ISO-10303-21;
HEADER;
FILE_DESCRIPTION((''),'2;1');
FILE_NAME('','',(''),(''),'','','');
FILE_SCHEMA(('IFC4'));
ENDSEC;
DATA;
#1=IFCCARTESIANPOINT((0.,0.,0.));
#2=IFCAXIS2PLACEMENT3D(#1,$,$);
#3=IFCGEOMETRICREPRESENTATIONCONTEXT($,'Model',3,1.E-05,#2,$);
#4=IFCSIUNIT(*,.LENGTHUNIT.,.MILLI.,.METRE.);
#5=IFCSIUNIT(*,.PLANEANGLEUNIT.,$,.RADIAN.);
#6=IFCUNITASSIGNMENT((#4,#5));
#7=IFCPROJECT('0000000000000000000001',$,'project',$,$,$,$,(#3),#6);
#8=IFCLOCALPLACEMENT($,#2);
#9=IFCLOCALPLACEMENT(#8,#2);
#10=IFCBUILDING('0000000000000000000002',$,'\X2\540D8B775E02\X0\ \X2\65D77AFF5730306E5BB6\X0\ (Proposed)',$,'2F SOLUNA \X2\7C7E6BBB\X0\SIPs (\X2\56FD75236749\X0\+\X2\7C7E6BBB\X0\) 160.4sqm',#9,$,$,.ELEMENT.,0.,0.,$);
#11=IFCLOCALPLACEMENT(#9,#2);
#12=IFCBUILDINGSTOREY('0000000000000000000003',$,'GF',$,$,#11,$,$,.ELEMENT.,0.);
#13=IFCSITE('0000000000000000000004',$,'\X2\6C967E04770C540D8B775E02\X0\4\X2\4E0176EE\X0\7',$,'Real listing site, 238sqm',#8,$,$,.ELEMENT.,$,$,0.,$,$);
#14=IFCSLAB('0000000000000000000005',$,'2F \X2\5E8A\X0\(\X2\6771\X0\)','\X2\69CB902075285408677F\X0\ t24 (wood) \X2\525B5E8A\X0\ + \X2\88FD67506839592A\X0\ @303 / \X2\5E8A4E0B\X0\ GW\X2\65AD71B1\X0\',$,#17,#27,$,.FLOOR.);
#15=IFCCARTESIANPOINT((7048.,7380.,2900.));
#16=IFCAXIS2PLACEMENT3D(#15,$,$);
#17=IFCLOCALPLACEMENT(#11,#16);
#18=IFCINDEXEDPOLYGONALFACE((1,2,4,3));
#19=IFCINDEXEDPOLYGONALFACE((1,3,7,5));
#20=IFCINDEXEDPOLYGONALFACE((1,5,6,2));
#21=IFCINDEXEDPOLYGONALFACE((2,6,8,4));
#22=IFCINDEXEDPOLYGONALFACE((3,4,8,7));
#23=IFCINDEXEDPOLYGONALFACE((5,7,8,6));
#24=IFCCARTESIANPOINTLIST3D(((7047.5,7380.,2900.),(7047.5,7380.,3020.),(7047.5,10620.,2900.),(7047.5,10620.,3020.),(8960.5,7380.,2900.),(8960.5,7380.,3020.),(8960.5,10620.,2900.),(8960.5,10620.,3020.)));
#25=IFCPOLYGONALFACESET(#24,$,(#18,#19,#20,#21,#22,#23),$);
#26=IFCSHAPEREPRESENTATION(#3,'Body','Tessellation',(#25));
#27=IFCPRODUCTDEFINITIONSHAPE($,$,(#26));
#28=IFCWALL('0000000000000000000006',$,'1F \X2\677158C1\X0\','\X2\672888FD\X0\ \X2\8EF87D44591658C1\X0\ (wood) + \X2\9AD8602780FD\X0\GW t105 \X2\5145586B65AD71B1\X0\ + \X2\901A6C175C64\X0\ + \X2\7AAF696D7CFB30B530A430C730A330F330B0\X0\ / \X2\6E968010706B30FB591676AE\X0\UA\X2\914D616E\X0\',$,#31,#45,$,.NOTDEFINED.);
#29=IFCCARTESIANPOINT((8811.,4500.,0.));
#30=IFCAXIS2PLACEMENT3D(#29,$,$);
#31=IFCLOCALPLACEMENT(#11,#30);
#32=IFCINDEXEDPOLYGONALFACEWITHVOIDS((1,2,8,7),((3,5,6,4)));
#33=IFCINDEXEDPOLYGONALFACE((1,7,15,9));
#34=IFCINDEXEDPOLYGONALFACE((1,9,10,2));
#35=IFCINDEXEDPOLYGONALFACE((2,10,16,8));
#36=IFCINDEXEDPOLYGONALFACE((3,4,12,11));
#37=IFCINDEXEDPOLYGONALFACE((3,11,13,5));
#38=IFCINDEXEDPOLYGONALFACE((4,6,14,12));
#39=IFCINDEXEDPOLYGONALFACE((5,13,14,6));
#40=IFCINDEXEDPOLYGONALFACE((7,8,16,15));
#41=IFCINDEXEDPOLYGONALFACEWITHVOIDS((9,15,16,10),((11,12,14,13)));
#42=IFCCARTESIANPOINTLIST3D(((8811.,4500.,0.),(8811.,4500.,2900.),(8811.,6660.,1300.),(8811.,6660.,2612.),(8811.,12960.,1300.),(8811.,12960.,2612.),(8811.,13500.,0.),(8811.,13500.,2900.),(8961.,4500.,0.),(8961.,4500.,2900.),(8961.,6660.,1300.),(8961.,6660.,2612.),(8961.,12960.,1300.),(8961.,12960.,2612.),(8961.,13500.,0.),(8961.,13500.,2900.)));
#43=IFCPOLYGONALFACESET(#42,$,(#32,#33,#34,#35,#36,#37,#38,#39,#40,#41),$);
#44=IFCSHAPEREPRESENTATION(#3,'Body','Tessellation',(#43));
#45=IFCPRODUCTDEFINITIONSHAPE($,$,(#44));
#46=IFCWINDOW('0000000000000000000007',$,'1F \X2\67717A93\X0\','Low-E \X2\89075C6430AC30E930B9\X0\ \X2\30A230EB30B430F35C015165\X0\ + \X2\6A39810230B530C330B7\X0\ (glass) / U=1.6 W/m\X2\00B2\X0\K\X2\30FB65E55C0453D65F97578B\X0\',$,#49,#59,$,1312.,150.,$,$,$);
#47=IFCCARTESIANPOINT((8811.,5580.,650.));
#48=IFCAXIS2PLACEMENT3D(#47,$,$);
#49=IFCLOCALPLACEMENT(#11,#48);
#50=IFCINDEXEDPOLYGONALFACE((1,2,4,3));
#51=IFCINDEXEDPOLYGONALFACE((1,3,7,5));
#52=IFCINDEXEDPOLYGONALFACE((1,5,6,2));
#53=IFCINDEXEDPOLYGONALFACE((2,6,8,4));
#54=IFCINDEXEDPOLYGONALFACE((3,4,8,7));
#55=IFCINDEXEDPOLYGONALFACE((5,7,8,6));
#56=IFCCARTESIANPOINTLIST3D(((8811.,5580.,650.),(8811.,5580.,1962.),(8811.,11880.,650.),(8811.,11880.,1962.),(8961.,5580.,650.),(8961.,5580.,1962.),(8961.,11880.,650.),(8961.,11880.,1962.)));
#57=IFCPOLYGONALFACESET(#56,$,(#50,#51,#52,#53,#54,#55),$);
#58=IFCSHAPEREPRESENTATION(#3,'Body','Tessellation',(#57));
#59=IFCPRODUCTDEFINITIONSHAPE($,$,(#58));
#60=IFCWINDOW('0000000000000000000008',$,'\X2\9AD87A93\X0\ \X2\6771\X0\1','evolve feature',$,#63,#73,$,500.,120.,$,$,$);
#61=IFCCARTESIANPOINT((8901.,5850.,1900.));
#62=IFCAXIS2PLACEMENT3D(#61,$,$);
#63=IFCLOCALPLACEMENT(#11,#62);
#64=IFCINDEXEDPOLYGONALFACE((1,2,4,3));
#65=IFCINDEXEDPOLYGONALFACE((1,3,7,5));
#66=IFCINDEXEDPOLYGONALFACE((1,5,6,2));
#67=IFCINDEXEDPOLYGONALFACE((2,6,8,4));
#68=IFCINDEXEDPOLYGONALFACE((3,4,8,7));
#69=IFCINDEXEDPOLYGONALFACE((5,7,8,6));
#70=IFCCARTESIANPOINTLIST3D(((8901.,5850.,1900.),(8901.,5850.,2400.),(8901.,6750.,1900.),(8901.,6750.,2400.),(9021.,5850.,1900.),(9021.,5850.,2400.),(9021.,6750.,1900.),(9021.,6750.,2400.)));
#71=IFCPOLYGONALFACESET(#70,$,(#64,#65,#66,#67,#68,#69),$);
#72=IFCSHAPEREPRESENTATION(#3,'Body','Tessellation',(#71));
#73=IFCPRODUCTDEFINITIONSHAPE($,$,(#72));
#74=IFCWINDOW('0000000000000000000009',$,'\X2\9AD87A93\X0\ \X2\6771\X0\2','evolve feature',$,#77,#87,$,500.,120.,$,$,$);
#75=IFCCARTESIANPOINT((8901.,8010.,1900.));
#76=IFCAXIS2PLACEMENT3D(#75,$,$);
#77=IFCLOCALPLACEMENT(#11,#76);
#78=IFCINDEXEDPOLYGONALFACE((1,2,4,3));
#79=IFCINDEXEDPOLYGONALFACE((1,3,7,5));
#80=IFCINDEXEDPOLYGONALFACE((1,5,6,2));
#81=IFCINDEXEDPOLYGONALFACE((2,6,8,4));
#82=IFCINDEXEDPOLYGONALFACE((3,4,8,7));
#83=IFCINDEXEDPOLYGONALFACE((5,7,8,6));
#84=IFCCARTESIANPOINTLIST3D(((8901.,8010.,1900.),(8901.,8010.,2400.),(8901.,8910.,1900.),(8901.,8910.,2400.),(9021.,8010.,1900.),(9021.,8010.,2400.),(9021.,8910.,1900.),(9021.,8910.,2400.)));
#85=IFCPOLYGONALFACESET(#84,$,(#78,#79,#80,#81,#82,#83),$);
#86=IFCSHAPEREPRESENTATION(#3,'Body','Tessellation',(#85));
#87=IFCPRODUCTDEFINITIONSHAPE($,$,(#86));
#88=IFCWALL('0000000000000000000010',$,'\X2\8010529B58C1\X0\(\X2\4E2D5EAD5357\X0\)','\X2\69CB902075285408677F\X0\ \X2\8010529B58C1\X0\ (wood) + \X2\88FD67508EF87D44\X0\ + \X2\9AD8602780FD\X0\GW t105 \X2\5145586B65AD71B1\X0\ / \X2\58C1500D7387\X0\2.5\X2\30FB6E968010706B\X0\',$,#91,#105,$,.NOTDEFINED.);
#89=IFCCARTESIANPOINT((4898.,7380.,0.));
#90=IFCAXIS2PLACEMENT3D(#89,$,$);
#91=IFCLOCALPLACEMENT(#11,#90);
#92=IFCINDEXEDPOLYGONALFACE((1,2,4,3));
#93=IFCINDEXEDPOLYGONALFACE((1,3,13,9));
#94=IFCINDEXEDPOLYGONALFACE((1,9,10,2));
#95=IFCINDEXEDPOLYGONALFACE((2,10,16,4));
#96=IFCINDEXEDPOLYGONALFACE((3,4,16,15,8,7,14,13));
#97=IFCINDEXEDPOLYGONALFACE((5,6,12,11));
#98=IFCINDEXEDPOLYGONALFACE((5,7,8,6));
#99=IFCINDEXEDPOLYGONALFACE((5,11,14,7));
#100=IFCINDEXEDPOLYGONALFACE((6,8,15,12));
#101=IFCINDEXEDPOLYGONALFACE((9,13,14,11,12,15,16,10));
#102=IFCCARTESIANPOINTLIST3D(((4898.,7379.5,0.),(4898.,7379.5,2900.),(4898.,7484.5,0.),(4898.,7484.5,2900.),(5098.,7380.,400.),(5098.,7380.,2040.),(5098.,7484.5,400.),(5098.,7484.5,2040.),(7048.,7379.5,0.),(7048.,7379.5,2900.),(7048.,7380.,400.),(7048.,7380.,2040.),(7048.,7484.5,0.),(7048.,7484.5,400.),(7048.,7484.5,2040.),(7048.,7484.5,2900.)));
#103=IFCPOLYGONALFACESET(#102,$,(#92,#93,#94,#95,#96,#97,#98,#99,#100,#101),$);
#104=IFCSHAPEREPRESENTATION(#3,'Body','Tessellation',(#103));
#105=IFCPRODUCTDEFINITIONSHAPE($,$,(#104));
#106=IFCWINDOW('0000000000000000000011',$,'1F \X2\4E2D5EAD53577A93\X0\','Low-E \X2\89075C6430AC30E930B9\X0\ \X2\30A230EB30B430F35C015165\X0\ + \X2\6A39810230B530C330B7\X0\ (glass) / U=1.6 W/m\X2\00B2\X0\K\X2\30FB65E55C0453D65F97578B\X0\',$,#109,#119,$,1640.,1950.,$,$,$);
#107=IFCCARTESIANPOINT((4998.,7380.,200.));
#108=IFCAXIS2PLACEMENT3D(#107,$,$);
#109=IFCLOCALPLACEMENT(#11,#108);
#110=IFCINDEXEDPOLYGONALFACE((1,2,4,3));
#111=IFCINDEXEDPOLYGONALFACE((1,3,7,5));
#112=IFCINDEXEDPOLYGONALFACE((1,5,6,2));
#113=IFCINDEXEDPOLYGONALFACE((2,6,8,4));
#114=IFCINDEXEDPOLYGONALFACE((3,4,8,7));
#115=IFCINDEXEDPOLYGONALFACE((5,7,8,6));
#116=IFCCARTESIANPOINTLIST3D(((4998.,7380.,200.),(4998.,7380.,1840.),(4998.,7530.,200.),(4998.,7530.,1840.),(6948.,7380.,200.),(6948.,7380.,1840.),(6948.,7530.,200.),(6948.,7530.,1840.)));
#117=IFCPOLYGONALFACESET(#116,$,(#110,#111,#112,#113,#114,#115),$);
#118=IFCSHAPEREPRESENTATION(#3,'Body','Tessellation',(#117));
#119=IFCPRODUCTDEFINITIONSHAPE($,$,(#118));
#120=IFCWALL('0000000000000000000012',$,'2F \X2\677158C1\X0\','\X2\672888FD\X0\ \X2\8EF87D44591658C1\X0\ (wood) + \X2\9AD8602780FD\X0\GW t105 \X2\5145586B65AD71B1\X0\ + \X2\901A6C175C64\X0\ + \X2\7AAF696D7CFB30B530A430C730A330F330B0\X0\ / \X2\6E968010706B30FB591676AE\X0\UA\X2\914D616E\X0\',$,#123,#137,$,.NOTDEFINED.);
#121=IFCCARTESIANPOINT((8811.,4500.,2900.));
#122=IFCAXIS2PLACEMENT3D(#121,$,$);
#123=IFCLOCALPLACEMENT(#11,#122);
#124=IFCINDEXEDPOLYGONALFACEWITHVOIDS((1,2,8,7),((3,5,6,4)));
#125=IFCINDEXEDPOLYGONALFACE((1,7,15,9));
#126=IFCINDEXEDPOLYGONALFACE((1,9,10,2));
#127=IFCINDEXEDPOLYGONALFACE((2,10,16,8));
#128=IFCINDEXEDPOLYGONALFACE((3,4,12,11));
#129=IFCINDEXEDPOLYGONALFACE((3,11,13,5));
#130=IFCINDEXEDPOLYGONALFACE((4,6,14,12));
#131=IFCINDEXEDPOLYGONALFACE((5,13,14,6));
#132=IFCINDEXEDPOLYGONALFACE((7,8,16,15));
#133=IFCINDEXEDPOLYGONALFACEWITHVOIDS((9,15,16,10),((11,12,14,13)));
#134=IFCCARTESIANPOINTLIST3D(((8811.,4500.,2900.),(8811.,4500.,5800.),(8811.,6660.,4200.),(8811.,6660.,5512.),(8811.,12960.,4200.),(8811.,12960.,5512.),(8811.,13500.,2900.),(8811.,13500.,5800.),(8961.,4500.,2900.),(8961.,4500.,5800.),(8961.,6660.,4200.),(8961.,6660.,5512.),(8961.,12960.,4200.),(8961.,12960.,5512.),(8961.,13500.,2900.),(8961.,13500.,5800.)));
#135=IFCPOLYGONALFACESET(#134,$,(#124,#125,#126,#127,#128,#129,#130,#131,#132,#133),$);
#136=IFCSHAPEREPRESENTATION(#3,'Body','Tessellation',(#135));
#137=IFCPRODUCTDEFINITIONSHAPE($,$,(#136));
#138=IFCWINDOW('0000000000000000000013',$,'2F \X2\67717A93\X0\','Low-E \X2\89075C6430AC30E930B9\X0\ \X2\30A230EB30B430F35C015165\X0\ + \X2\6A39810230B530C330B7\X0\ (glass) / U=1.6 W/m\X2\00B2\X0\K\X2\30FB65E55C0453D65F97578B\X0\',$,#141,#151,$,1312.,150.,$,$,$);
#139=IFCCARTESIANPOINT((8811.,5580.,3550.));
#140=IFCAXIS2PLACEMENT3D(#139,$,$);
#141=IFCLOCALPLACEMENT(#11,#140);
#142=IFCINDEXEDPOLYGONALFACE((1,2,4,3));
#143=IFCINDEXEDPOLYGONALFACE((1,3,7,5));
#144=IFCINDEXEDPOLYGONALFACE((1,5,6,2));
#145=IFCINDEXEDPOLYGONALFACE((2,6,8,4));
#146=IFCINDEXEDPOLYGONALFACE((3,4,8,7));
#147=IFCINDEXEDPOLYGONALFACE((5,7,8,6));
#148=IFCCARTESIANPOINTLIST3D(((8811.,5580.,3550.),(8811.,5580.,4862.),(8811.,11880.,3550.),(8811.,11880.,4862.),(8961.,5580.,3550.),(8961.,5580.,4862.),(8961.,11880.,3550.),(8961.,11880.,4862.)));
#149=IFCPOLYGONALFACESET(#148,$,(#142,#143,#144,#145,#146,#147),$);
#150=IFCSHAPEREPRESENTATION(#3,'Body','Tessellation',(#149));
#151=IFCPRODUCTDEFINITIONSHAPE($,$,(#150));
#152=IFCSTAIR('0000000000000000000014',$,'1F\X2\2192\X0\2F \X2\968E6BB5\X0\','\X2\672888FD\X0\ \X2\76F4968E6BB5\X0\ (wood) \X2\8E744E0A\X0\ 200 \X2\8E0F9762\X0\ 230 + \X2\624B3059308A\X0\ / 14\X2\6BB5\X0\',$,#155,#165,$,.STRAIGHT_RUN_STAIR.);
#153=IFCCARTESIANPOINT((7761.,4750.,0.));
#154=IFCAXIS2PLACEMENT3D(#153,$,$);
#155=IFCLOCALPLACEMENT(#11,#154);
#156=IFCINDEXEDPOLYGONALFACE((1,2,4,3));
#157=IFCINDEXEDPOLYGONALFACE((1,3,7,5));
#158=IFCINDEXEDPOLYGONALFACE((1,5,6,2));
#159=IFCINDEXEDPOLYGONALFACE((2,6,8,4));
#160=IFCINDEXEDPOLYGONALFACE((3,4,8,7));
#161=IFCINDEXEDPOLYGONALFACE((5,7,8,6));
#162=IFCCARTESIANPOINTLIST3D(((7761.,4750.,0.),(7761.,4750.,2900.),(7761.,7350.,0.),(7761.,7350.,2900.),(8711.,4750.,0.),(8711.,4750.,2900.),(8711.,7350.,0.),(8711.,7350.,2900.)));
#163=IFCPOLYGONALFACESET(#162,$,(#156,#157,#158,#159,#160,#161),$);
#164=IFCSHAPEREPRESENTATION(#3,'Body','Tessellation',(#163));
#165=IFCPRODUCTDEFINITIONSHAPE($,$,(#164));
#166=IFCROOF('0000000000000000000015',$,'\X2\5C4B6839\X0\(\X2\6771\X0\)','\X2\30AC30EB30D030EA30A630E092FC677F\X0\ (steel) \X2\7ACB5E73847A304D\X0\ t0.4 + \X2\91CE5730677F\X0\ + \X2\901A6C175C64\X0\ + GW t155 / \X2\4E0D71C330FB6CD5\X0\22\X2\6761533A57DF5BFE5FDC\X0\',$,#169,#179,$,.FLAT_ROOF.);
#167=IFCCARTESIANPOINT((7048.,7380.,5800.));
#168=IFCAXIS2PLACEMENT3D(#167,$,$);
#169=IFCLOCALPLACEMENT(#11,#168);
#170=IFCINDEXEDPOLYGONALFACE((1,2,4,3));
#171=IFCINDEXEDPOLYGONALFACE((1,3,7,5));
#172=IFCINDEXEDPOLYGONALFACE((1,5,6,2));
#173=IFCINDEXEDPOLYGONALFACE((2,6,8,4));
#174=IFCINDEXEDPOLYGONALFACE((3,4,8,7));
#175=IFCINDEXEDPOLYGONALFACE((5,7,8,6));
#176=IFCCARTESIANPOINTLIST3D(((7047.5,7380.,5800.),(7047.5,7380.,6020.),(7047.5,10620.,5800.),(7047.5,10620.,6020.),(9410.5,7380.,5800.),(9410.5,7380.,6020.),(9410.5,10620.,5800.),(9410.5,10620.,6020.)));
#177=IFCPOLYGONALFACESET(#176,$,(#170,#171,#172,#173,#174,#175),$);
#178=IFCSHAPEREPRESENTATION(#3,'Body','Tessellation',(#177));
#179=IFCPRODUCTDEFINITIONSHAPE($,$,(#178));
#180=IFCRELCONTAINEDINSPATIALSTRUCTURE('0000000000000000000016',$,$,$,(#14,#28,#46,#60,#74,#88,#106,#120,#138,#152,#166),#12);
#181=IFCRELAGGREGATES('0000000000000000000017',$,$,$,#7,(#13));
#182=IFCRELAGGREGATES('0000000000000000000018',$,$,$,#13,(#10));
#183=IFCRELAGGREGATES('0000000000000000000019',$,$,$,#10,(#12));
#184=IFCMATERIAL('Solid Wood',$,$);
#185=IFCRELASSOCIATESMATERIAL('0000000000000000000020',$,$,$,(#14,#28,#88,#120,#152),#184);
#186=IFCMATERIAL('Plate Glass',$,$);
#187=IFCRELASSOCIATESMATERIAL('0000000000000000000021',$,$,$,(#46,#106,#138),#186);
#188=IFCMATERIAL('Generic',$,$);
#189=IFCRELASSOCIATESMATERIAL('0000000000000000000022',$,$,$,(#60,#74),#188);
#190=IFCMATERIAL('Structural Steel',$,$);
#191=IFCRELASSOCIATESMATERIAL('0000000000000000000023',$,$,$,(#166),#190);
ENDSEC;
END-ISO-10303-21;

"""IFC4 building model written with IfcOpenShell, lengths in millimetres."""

from ifc_helpers import new_model, si_unit, frame, frame_2d, origin, place, context, project, spatial, rectangle, extrude, material, element, fill, save


model = new_model("IFC4")

# Units and contexts
model_context = context("Model", 3, precision=1e-05, world=origin())
ifc_project = project(units=[si_unit("LENGTHUNIT", "METRE", prefix="MILLI"), si_unit("PLANEANGLEUNIT", "RADIAN")], contexts=[model_context])

# Site, building, storey
site_placement = place(None, origin())
site = spatial("IfcSite", under=ifc_project, at=site_placement, Name="沖縄県名護市4丁目7", ObjectType="Real listing site, 238sqm", CompositionType="ELEMENT", RefElevation=0.0)
building_placement = place(site_placement, origin())
building = spatial("IfcBuilding", under=site, at=building_placement, Name="名護市 旗竿地の家 (Proposed)", ObjectType="2F SOLUNA 籾殻SIPs (国産杉+籾殻) 160.4sqm", CompositionType="ELEMENT", ElevationOfRefHeight=0.0, ElevationOfTerrain=0.0)
storey_placement = place(building_placement, origin())
storey = spatial("IfcBuildingStorey", under=building, at=storey_placement, Name="GF", CompositionType="ELEMENT", Elevation=0.0)

# Slab
ifc_material_1 = material(Name="Solid Wood")
slab_1_placement = place(storey_placement, frame((7048.0, 7380.0, 2900.0)))
element("IfcSlab", 1, at=slab_1_placement, inside=storey, material=ifc_material_1, Name="2F 床(東)", Description="構造用合板 t24 (wood) 剛床 + 製材根太 @303 / 床下 GW断熱", PredefinedType="FLOOR", context=model_context, shape_type="SweptSolid", body=[
    extrude(rectangle(XDim=1913.0, YDim=3240.0, at=frame_2d((956.0, 1620.0))), frame((7048.0, 7380.0, 2900.0)), (0.0, 0.0, 1.0), 120.0),
])

# Wall, openings, windows
wall_1_placement = place(storey_placement, frame((8811.0, 4500.0, 0.0)))
wall_1 = element("IfcWall", 2, at=wall_1_placement, inside=storey, material=ifc_material_1, Name="1F 東壁", Description="木製 軸組外壁 (wood) + 高性能GW t105 充填断熱 + 通気層 + 窯業系サイディング / 準耐火・外皮UA配慮", PredefinedType="NOTDEFINED", context=model_context, shape_type="SweptSolid", body=[
    extrude(rectangle(XDim=150.0, YDim=9000.0, at=frame_2d((75.0, 4500.0))), frame((8811.0, 4500.0, 0.0)), (0.0, 0.0, 1.0), 2900.0),
])
opening_1_placement = place(storey_placement, frame((8811.0, 5580.0, 650.0)))
opening_1 = element("IfcOpeningElement", 3, at=opening_1_placement, cuts=wall_1, PredefinedType="NOTDEFINED", context=model_context, shape_type="SweptSolid", body=[
    extrude(rectangle(XDim=150.0, YDim=6300.0, at=frame_2d((75.0, 3150.0))), frame((8811.0, 5580.0, 650.0)), (0.0, 0.0, 1.0), 1312.0),
])
opening_2_placement = place(storey_placement, frame((8901.0, 5850.0, 1900.0)))
opening_2 = element("IfcOpeningElement", 4, at=opening_2_placement, cuts=wall_1, PredefinedType="NOTDEFINED", context=model_context, shape_type="SweptSolid", body=[
    extrude(rectangle(XDim=120.0, YDim=900.0, at=frame_2d((60.0, 450.0))), frame((8901.0, 5850.0, 1900.0)), (0.0, 0.0, 1.0), 500.0),
])
opening_3_placement = place(storey_placement, frame((8901.0, 8010.0, 1900.0)))
opening_3 = element("IfcOpeningElement", 5, at=opening_3_placement, cuts=wall_1, PredefinedType="NOTDEFINED", context=model_context, shape_type="SweptSolid", body=[
    extrude(rectangle(XDim=120.0, YDim=900.0, at=frame_2d((60.0, 450.0))), frame((8901.0, 8010.0, 1900.0)), (0.0, 0.0, 1.0), 500.0),
])
ifc_material_2 = material(Name="Plate Glass")
window_1_placement = place(storey_placement, frame((8811.0, 5580.0, 650.0)))
window_1 = element("IfcWindow", 6, at=window_1_placement, inside=storey, material=ifc_material_2, Name="1F 東窓", Description="Low-E 複層ガラス アルゴン封入 + 樹脂サッシ (glass) / U=1.6 W/m²K・日射取得型", OverallHeight=1312.0, OverallWidth=150.0, context=model_context, shape_type="SweptSolid", body=[
    extrude(rectangle(XDim=150.0, YDim=6300.0, at=frame_2d((75.0, 3150.0))), frame((8811.0, 5580.0, 650.0)), (0.0, 0.0, 1.0), 1312.0),
])
fill(opening_1, window_1)
ifc_material_3 = material(Name="Generic")
window_2_placement = place(storey_placement, frame((8901.0, 5850.0, 1900.0)))
window_2 = element("IfcWindow", 7, at=window_2_placement, inside=storey, material=ifc_material_3, Name="高窓 東1", Description="evolve feature", OverallHeight=500.0, OverallWidth=120.0, context=model_context, shape_type="SweptSolid", body=[
    extrude(rectangle(XDim=120.0, YDim=900.0, at=frame_2d((60.0, 450.0))), frame((8901.0, 5850.0, 1900.0)), (0.0, 0.0, 1.0), 500.0),
])
fill(opening_2, window_2)
window_3_placement = place(storey_placement, frame((8901.0, 8010.0, 1900.0)))
window_3 = element("IfcWindow", 8, at=window_3_placement, inside=storey, material=ifc_material_3, Name="高窓 東2", Description="evolve feature", OverallHeight=500.0, OverallWidth=120.0, context=model_context, shape_type="SweptSolid", body=[
    extrude(rectangle(XDim=120.0, YDim=900.0, at=frame_2d((60.0, 450.0))), frame((8901.0, 8010.0, 1900.0)), (0.0, 0.0, 1.0), 500.0),
])
fill(opening_3, window_3)

# Wall, opening, window
wall_2_placement = place(storey_placement, frame((4898.0, 7380.0, 0.0)))
wall_2 = element("IfcWall", 9, at=wall_2_placement, inside=storey, material=ifc_material_1, Name="耐力壁(中庭南)", Description="構造用合板 耐力壁 (wood) + 製材軸組 + 高性能GW t105 充填断熱 / 壁倍率2.5・準耐火", PredefinedType="NOTDEFINED", context=model_context, shape_type="SweptSolid", body=[
    extrude(rectangle(XDim=2150.0, YDim=105.0, at=frame_2d((1075.0, 52.0))), frame((4898.0, 7380.0, 0.0)), (0.0, 0.0, 1.0), 2900.0),
])
opening_4_placement = place(storey_placement, frame((4998.0, 7380.0, 200.0)))
opening_4 = element("IfcOpeningElement", 10, at=opening_4_placement, cuts=wall_2, PredefinedType="NOTDEFINED", context=model_context, shape_type="SweptSolid", body=[
    extrude(rectangle(XDim=1950.0, YDim=150.0, at=frame_2d((975.0, 75.0))), frame((4998.0, 7380.0, 200.0)), (0.0, 0.0, 1.0), 1640.0),
])
window_4_placement = place(storey_placement, frame((4998.0, 7380.0, 200.0)))
window_4 = element("IfcWindow", 11, at=window_4_placement, inside=storey, material=ifc_material_2, Name="1F 中庭南窓", Description="Low-E 複層ガラス アルゴン封入 + 樹脂サッシ (glass) / U=1.6 W/m²K・日射取得型", OverallHeight=1640.0, OverallWidth=1950.0, context=model_context, shape_type="SweptSolid", body=[
    extrude(rectangle(XDim=1950.0, YDim=150.0, at=frame_2d((975.0, 75.0))), frame((4998.0, 7380.0, 200.0)), (0.0, 0.0, 1.0), 1640.0),
])
fill(opening_4, window_4)

# Wall, opening, window
wall_3_placement = place(storey_placement, frame((8811.0, 4500.0, 2900.0)))
wall_3 = element("IfcWall", 12, at=wall_3_placement, inside=storey, material=ifc_material_1, Name="2F 東壁", Description="木製 軸組外壁 (wood) + 高性能GW t105 充填断熱 + 通気層 + 窯業系サイディング / 準耐火・外皮UA配慮", PredefinedType="NOTDEFINED", context=model_context, shape_type="SweptSolid", body=[
    extrude(rectangle(XDim=150.0, YDim=9000.0, at=frame_2d((75.0, 4500.0))), frame((8811.0, 4500.0, 2900.0)), (0.0, 0.0, 1.0), 2900.0),
])
opening_5_placement = place(storey_placement, frame((8811.0, 5580.0, 3550.0)))
opening_5 = element("IfcOpeningElement", 13, at=opening_5_placement, cuts=wall_3, PredefinedType="NOTDEFINED", context=model_context, shape_type="SweptSolid", body=[
    extrude(rectangle(XDim=150.0, YDim=6300.0, at=frame_2d((75.0, 3150.0))), frame((8811.0, 5580.0, 3550.0)), (0.0, 0.0, 1.0), 1312.0),
])
window_5_placement = place(storey_placement, frame((8811.0, 5580.0, 3550.0)))
window_5 = element("IfcWindow", 14, at=window_5_placement, inside=storey, material=ifc_material_2, Name="2F 東窓", Description="Low-E 複層ガラス アルゴン封入 + 樹脂サッシ (glass) / U=1.6 W/m²K・日射取得型", OverallHeight=1312.0, OverallWidth=150.0, context=model_context, shape_type="SweptSolid", body=[
    extrude(rectangle(XDim=150.0, YDim=6300.0, at=frame_2d((75.0, 3150.0))), frame((8811.0, 5580.0, 3550.0)), (0.0, 0.0, 1.0), 1312.0),
])
fill(opening_5, window_5)

# Stair
stair_placement = place(storey_placement, frame((7761.0, 4750.0, 0.0)))
element("IfcStair", 15, at=stair_placement, inside=storey, material=ifc_material_1, Name="1F→2F 階段", Description="木製 直階段 (wood) 蹴上 200 踏面 230 + 手すり / 14段", PredefinedType="STRAIGHT_RUN_STAIR", context=model_context, shape_type="SweptSolid", body=[
    extrude(rectangle(XDim=950.0, YDim=2600.0, at=frame_2d((475.0, 1300.0))), frame((7761.0, 4750.0, 0.0)), (0.0, 0.0, 1.0), 2900.0),
])

# Roof
ifc_material_4 = material(Name="Structural Steel")
roof_placement = place(storey_placement, frame((7048.0, 7380.0, 5800.0)))
element("IfcRoof", 16, at=roof_placement, inside=storey, material=ifc_material_4, Name="屋根(東)", Description="ガルバリウム鋼板 (steel) 立平葺き t0.4 + 野地板 + 通気層 + GW t155 / 不燃・法22条区域対応", PredefinedType="FLAT_ROOF", context=model_context, shape_type="SweptSolid", body=[
    extrude(rectangle(XDim=2363.0, YDim=3240.0, at=frame_2d((1181.0, 1620.0))), frame((7048.0, 7380.0, 5800.0)), (0.0, 0.0, 1.0), 220.0),
])

save(model, "model.ifc")
